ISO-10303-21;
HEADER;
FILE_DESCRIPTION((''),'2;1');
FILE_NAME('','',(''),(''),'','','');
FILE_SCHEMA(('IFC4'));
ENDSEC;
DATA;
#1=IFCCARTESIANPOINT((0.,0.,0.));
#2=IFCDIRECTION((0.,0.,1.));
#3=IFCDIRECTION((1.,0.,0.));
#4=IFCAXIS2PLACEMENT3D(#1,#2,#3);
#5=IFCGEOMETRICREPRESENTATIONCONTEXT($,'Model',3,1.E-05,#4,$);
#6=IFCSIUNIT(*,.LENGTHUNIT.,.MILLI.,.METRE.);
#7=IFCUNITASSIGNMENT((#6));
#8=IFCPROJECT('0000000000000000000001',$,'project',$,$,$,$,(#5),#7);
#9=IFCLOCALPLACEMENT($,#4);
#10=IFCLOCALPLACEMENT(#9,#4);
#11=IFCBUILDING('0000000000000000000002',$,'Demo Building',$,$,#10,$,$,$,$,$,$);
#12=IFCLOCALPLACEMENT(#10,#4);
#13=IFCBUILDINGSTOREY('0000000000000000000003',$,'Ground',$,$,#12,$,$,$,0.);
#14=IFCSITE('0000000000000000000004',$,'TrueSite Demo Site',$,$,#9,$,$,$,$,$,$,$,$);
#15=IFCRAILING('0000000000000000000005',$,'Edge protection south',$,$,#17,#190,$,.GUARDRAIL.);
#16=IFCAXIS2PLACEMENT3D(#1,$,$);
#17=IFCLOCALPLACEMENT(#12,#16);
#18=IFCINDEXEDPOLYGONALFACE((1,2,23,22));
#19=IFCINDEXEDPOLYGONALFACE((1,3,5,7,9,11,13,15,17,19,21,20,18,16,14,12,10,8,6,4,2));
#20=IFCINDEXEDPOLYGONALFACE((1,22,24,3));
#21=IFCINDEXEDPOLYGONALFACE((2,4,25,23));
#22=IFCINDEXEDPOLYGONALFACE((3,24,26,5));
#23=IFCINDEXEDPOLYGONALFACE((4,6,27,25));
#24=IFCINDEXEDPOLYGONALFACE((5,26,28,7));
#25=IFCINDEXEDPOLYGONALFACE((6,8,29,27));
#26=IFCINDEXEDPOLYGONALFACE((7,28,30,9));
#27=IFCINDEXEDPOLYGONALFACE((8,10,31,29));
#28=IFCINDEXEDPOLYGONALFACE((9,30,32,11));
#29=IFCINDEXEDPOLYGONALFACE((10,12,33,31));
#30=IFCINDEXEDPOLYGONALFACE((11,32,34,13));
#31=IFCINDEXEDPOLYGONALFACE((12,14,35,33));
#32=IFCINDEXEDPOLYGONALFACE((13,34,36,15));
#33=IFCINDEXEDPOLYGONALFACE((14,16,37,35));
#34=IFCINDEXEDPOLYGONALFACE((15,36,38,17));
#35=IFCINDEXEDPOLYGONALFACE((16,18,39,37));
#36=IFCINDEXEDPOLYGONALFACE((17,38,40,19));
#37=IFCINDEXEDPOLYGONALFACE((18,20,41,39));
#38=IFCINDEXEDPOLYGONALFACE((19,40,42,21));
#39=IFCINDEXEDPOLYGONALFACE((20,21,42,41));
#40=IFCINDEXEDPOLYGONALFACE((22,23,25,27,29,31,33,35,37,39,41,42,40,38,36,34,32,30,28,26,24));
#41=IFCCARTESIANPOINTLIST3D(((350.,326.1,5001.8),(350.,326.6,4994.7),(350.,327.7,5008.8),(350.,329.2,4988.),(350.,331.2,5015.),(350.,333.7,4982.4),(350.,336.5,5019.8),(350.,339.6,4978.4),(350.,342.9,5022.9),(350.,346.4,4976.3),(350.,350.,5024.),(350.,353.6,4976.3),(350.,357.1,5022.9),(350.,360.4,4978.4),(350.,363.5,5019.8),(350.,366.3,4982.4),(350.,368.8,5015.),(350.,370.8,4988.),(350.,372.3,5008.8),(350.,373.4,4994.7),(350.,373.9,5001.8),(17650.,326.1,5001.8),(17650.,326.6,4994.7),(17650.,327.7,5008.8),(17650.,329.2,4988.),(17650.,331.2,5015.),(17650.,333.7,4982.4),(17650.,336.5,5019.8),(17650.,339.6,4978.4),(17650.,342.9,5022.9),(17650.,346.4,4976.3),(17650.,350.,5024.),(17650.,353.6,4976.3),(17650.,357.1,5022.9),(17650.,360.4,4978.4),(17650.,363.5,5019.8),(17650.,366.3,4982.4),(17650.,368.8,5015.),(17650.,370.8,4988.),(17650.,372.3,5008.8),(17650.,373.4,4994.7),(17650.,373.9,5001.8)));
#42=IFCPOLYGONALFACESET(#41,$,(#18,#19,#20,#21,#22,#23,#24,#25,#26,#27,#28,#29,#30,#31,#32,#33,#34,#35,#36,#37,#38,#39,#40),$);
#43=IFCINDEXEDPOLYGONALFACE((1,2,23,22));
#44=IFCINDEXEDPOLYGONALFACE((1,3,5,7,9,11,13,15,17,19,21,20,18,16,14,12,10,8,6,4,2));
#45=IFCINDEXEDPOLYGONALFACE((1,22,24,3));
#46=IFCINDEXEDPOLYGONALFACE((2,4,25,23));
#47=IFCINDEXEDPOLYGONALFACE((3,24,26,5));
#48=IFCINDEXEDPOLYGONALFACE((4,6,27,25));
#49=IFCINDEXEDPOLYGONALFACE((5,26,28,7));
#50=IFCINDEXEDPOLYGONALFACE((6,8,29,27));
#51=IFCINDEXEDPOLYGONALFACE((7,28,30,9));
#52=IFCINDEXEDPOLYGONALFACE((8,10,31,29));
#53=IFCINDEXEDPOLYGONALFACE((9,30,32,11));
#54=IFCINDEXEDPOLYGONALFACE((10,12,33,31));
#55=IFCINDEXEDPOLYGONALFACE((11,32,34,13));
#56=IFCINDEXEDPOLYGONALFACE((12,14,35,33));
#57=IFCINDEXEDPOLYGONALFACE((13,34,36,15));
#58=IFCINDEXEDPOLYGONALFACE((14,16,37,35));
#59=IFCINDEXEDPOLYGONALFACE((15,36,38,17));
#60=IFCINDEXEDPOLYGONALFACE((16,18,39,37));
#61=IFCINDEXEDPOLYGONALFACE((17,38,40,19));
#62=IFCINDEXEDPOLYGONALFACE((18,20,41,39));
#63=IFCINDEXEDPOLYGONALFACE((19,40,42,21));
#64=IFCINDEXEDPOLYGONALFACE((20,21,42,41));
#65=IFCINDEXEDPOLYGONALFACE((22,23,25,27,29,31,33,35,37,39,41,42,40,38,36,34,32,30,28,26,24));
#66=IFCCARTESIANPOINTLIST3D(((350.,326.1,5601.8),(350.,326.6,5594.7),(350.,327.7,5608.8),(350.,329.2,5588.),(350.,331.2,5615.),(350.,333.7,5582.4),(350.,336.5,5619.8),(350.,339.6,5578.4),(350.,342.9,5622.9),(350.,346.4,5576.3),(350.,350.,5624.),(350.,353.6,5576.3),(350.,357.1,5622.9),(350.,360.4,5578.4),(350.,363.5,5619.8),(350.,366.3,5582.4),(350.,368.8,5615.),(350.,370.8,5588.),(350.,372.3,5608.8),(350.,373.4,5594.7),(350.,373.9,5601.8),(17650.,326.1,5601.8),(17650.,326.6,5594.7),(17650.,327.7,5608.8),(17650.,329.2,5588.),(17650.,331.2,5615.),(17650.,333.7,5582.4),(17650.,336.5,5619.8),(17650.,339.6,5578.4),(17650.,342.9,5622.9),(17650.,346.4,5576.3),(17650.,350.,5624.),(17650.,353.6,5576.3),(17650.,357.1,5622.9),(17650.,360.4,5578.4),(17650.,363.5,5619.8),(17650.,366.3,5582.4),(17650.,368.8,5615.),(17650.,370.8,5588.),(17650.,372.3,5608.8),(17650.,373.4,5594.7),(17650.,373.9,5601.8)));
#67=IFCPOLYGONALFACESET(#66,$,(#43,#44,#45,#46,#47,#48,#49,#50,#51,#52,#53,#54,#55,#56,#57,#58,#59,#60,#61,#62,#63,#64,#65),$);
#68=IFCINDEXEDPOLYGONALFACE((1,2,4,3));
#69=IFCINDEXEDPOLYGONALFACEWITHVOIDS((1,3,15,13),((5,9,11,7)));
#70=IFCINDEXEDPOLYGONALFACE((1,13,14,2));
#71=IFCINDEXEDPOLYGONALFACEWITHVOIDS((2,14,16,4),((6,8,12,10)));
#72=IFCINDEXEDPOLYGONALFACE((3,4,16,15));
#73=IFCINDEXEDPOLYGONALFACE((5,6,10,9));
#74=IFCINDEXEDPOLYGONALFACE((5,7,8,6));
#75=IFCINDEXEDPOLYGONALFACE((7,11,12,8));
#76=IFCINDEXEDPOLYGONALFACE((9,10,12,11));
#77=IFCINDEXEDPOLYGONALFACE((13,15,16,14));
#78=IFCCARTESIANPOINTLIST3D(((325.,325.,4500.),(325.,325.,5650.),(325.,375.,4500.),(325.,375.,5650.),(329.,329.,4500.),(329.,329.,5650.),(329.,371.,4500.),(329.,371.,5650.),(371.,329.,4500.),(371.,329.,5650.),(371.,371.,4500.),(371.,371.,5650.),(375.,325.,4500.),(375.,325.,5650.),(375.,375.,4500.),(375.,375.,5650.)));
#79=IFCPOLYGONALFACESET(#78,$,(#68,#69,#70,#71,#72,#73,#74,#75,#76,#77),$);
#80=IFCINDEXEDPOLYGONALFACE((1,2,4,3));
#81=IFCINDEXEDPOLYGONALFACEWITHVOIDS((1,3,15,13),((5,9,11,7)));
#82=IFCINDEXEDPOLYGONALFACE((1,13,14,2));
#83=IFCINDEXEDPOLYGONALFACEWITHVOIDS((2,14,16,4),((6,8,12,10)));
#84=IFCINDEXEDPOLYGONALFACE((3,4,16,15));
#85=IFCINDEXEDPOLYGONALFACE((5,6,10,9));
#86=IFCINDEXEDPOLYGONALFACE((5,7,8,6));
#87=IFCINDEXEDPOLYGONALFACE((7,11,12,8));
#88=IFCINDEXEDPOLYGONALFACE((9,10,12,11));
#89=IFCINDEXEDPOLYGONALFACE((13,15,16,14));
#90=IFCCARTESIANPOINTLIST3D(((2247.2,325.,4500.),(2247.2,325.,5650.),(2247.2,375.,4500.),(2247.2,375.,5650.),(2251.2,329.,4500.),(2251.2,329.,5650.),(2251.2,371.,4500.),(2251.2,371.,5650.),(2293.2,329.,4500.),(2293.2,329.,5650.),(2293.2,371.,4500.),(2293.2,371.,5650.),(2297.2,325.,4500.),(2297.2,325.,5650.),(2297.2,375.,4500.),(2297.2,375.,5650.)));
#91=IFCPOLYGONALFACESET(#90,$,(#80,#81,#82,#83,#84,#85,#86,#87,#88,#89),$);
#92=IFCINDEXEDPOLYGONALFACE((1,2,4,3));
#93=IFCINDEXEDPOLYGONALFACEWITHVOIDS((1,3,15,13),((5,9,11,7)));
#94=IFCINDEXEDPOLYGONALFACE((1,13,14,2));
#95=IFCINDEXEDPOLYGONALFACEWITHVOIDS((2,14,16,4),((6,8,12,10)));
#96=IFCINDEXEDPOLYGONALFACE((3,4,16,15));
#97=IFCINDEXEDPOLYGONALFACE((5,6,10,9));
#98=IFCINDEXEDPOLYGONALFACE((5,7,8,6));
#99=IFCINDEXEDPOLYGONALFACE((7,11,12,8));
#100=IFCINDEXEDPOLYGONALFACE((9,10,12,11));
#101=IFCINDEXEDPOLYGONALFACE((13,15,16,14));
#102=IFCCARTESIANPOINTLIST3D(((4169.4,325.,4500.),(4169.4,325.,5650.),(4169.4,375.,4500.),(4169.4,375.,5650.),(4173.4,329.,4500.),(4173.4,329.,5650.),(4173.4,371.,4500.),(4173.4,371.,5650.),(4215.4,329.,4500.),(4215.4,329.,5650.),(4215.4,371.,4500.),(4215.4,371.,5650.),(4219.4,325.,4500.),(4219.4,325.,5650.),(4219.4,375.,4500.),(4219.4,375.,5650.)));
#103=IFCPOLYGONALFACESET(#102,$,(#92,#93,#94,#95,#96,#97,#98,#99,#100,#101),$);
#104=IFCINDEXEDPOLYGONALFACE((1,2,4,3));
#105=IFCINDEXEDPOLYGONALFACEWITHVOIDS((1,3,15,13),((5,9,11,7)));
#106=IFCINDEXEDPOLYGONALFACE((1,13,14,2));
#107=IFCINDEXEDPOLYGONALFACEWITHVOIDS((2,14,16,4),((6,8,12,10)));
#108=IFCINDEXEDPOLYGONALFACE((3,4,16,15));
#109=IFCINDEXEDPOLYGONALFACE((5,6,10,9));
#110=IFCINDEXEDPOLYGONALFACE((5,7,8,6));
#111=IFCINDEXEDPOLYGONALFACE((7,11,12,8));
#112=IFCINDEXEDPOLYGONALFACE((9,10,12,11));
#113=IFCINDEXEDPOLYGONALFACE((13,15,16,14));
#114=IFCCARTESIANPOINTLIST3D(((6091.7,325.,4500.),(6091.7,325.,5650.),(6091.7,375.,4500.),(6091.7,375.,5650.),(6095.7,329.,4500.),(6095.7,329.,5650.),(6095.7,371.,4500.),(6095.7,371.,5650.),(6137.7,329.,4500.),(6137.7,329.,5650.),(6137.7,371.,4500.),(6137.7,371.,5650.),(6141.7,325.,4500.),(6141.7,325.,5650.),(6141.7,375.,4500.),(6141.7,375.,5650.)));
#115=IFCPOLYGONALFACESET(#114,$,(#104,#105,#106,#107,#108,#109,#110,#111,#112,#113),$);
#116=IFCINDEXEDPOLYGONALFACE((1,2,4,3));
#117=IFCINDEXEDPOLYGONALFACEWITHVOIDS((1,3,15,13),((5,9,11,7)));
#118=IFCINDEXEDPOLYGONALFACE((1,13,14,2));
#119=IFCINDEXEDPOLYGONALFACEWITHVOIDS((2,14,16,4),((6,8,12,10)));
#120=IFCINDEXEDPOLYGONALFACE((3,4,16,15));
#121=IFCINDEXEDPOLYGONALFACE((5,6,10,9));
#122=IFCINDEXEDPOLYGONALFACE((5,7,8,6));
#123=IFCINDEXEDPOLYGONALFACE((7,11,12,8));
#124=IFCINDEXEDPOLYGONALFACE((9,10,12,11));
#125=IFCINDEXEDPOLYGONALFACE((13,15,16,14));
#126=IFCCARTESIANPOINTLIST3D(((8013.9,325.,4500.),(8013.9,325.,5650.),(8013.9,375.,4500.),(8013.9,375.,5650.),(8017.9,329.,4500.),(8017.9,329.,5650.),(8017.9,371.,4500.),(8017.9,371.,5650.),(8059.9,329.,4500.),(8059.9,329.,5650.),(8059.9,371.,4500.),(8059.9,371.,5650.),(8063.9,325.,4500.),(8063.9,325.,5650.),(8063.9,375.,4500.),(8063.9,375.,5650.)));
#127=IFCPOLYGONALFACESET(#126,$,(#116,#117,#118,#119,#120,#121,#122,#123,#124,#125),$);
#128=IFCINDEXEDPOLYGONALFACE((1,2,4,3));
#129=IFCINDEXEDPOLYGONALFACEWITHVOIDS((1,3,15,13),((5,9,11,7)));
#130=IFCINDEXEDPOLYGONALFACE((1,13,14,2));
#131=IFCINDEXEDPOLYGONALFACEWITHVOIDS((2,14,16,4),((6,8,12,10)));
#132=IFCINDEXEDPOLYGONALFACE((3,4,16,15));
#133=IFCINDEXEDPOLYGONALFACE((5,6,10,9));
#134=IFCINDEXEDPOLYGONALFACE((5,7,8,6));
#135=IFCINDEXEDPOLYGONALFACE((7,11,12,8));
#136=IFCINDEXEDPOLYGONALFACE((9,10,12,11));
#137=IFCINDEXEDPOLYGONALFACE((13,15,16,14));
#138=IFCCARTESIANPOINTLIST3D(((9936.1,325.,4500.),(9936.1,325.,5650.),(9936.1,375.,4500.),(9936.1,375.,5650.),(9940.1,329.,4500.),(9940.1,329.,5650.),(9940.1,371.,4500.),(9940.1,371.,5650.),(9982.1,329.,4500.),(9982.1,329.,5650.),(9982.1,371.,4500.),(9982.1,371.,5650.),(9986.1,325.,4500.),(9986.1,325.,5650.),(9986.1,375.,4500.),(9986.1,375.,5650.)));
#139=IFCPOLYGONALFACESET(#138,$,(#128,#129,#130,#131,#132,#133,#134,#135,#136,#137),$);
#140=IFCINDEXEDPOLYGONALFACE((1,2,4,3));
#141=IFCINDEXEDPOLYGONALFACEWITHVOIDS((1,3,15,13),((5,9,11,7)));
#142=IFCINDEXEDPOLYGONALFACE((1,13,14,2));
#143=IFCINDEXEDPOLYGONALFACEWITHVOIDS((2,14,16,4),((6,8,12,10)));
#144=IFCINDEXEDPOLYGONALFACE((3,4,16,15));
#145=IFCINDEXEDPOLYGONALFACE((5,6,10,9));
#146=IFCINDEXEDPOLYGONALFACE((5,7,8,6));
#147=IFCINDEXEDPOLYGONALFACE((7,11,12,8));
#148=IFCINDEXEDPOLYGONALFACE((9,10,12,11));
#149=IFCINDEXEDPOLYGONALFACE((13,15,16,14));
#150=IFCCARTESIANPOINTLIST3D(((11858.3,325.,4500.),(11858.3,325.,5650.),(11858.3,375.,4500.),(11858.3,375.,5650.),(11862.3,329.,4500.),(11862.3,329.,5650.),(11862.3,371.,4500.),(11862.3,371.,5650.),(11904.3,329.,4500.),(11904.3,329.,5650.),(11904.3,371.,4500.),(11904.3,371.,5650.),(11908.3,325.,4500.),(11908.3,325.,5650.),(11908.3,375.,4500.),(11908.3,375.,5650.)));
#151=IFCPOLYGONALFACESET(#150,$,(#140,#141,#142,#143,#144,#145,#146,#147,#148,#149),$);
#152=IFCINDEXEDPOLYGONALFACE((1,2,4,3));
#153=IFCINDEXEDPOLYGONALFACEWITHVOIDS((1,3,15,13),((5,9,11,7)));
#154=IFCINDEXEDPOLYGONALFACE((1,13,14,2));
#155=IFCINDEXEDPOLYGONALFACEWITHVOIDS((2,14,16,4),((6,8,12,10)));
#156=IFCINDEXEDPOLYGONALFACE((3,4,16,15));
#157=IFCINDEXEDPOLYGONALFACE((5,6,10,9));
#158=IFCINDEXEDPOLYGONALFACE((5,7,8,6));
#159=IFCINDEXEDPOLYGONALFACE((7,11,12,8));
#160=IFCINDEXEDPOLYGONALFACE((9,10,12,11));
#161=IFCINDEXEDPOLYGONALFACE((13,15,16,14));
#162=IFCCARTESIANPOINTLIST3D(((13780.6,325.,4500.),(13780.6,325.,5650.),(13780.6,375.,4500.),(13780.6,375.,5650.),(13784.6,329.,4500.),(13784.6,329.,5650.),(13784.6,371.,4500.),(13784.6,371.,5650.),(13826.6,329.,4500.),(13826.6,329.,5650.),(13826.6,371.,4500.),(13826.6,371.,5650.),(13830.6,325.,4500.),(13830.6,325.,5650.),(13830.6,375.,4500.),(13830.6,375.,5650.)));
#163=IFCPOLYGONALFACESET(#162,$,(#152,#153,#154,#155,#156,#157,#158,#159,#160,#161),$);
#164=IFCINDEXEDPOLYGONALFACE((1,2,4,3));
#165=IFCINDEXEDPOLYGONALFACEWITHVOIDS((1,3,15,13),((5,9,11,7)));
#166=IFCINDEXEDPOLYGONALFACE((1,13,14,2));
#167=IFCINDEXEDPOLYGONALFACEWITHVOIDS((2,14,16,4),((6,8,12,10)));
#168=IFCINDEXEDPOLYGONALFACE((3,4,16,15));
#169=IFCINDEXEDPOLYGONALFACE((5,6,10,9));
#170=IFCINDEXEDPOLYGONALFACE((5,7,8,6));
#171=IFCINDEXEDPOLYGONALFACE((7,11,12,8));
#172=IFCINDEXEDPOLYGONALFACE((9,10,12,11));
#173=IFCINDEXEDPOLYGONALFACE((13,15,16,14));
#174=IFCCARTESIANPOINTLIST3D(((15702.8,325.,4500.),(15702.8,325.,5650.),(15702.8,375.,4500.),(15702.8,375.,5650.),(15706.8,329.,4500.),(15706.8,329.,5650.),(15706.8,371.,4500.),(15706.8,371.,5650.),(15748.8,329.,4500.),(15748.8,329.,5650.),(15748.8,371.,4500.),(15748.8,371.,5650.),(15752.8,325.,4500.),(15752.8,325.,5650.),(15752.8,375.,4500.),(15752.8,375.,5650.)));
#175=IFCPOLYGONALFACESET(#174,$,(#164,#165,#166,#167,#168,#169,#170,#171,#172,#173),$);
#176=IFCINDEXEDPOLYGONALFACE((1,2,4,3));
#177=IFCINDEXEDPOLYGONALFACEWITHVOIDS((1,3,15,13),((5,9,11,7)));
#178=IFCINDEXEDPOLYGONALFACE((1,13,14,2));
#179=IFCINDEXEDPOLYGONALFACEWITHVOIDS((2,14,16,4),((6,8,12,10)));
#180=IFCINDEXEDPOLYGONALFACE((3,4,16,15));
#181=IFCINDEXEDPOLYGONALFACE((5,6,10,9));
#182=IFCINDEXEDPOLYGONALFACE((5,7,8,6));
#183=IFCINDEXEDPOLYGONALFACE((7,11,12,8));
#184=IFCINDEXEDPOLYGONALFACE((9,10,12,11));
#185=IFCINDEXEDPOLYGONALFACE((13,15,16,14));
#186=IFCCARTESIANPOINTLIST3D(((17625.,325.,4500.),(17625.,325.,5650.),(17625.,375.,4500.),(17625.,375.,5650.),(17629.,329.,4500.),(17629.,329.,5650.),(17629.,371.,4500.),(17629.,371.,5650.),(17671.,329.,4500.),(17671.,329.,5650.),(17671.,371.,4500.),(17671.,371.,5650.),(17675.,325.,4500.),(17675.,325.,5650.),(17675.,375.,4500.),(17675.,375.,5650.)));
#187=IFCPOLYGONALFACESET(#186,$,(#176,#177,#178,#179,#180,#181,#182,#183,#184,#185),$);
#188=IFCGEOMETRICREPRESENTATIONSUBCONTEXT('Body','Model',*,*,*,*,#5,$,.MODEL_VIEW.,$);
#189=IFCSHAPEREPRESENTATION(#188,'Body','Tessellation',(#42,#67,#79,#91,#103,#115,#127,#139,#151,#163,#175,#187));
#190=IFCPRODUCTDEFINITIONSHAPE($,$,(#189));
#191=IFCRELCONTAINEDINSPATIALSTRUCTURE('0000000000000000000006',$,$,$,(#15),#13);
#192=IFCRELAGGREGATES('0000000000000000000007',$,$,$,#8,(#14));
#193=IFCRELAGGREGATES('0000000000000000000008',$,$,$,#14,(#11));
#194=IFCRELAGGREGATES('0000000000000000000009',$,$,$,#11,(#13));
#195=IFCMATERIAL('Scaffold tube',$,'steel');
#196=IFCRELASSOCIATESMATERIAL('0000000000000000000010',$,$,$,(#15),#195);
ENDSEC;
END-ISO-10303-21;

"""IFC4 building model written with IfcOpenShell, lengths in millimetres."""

from ifc_helpers import new_model, si_unit, frame, origin_with_axes, place, context, subcontext, project, spatial, hollow_rectangle, circle, extrude, material, element, save


model = new_model("IFC4")

# Units and contexts
model_context = context("Model", 3, precision=1e-05, world=origin_with_axes())
body_context = subcontext(model_context, "Body", "Model", "MODEL_VIEW")
ifc_project = project(units=[si_unit("LENGTHUNIT", "METRE", prefix="MILLI")], contexts=[model_context])

# Site, building, storey
site_placement = place(None, origin_with_axes())
site = spatial("IfcSite", under=ifc_project, at=site_placement, Name="TrueSite Demo Site")
building_placement = place(site_placement, origin_with_axes())
building = spatial("IfcBuilding", under=site, at=building_placement, Name="Demo Building")
storey_placement = place(building_placement, origin_with_axes())
storey = spatial("IfcBuildingStorey", under=building, at=storey_placement, Name="Ground", Elevation=0.0)

# Railing
ifc_material_1 = material(Name="Scaffold tube", Category="steel")
railing_1_placement = place(storey_placement, origin_with_axes())
element("IfcRailing", 1, at=railing_1_placement, inside=storey, material=ifc_material_1, Name="Edge protection south", PredefinedType="GUARDRAIL", context=body_context, shape_type="SweptSolid", body=[
    extrude(circle(Radius=24.0), frame((350.0, 350.0, 5000.0), z_axis=(1.0, 0.0, 0.0), x_axis=(0.0, 0.0, 1.0)), (0.0, 0.0, 1.0), 17300.0),
    extrude(circle(Radius=24.0), frame((350.0, 350.0, 5600.0), z_axis=(1.0, 0.0, 0.0), x_axis=(0.0, 0.0, 1.0)), (0.0, 0.0, 1.0), 17300.0),
    extrude(hollow_rectangle(XDim=50.0, YDim=50.0, WallThickness=4.0), frame((350.0, 350.0, 4500.0), z_axis=(0.0, 0.0, 1.0), x_axis=(1.0, 0.0, 0.0)), (0.0, 0.0, 1.0), 1150.0),
    extrude(hollow_rectangle(XDim=50.0, YDim=50.0, WallThickness=4.0), frame((2272.2, 350.0, 4500.0), z_axis=(0.0, 0.0, 1.0), x_axis=(1.0, 0.0, 0.0)), (0.0, 0.0, 1.0), 1150.0),
    extrude(hollow_rectangle(XDim=50.0, YDim=50.0, WallThickness=4.0), frame((4194.4, 350.0, 4500.0), z_axis=(0.0, 0.0, 1.0), x_axis=(1.0, 0.0, 0.0)), (0.0, 0.0, 1.0), 1150.0),
    extrude(hollow_rectangle(XDim=50.0, YDim=50.0, WallThickness=4.0), frame((6116.7, 350.0, 4500.0), z_axis=(0.0, 0.0, 1.0), x_axis=(1.0, 0.0, 0.0)), (0.0, 0.0, 1.0), 1150.0),
    extrude(hollow_rectangle(XDim=50.0, YDim=50.0, WallThickness=4.0), frame((8038.9, 350.0, 4500.0), z_axis=(0.0, 0.0, 1.0), x_axis=(1.0, 0.0, 0.0)), (0.0, 0.0, 1.0), 1150.0),
    extrude(hollow_rectangle(XDim=50.0, YDim=50.0, WallThickness=4.0), frame((9961.1, 350.0, 4500.0), z_axis=(0.0, 0.0, 1.0), x_axis=(1.0, 0.0, 0.0)), (0.0, 0.0, 1.0), 1150.0),
    extrude(hollow_rectangle(XDim=50.0, YDim=50.0, WallThickness=4.0), frame((11883.3, 350.0, 4500.0), z_axis=(0.0, 0.0, 1.0), x_axis=(1.0, 0.0, 0.0)), (0.0, 0.0, 1.0), 1150.0),
    extrude(hollow_rectangle(XDim=50.0, YDim=50.0, WallThickness=4.0), frame((13805.6, 350.0, 4500.0), z_axis=(0.0, 0.0, 1.0), x_axis=(1.0, 0.0, 0.0)), (0.0, 0.0, 1.0), 1150.0),
    extrude(hollow_rectangle(XDim=50.0, YDim=50.0, WallThickness=4.0), frame((15727.8, 350.0, 4500.0), z_axis=(0.0, 0.0, 1.0), x_axis=(1.0, 0.0, 0.0)), (0.0, 0.0, 1.0), 1150.0),
    extrude(hollow_rectangle(XDim=50.0, YDim=50.0, WallThickness=4.0), frame((17650.0, 350.0, 4500.0), z_axis=(0.0, 0.0, 1.0), x_axis=(1.0, 0.0, 0.0)), (0.0, 0.0, 1.0), 1150.0),
])

save(model, "model.ifc")
